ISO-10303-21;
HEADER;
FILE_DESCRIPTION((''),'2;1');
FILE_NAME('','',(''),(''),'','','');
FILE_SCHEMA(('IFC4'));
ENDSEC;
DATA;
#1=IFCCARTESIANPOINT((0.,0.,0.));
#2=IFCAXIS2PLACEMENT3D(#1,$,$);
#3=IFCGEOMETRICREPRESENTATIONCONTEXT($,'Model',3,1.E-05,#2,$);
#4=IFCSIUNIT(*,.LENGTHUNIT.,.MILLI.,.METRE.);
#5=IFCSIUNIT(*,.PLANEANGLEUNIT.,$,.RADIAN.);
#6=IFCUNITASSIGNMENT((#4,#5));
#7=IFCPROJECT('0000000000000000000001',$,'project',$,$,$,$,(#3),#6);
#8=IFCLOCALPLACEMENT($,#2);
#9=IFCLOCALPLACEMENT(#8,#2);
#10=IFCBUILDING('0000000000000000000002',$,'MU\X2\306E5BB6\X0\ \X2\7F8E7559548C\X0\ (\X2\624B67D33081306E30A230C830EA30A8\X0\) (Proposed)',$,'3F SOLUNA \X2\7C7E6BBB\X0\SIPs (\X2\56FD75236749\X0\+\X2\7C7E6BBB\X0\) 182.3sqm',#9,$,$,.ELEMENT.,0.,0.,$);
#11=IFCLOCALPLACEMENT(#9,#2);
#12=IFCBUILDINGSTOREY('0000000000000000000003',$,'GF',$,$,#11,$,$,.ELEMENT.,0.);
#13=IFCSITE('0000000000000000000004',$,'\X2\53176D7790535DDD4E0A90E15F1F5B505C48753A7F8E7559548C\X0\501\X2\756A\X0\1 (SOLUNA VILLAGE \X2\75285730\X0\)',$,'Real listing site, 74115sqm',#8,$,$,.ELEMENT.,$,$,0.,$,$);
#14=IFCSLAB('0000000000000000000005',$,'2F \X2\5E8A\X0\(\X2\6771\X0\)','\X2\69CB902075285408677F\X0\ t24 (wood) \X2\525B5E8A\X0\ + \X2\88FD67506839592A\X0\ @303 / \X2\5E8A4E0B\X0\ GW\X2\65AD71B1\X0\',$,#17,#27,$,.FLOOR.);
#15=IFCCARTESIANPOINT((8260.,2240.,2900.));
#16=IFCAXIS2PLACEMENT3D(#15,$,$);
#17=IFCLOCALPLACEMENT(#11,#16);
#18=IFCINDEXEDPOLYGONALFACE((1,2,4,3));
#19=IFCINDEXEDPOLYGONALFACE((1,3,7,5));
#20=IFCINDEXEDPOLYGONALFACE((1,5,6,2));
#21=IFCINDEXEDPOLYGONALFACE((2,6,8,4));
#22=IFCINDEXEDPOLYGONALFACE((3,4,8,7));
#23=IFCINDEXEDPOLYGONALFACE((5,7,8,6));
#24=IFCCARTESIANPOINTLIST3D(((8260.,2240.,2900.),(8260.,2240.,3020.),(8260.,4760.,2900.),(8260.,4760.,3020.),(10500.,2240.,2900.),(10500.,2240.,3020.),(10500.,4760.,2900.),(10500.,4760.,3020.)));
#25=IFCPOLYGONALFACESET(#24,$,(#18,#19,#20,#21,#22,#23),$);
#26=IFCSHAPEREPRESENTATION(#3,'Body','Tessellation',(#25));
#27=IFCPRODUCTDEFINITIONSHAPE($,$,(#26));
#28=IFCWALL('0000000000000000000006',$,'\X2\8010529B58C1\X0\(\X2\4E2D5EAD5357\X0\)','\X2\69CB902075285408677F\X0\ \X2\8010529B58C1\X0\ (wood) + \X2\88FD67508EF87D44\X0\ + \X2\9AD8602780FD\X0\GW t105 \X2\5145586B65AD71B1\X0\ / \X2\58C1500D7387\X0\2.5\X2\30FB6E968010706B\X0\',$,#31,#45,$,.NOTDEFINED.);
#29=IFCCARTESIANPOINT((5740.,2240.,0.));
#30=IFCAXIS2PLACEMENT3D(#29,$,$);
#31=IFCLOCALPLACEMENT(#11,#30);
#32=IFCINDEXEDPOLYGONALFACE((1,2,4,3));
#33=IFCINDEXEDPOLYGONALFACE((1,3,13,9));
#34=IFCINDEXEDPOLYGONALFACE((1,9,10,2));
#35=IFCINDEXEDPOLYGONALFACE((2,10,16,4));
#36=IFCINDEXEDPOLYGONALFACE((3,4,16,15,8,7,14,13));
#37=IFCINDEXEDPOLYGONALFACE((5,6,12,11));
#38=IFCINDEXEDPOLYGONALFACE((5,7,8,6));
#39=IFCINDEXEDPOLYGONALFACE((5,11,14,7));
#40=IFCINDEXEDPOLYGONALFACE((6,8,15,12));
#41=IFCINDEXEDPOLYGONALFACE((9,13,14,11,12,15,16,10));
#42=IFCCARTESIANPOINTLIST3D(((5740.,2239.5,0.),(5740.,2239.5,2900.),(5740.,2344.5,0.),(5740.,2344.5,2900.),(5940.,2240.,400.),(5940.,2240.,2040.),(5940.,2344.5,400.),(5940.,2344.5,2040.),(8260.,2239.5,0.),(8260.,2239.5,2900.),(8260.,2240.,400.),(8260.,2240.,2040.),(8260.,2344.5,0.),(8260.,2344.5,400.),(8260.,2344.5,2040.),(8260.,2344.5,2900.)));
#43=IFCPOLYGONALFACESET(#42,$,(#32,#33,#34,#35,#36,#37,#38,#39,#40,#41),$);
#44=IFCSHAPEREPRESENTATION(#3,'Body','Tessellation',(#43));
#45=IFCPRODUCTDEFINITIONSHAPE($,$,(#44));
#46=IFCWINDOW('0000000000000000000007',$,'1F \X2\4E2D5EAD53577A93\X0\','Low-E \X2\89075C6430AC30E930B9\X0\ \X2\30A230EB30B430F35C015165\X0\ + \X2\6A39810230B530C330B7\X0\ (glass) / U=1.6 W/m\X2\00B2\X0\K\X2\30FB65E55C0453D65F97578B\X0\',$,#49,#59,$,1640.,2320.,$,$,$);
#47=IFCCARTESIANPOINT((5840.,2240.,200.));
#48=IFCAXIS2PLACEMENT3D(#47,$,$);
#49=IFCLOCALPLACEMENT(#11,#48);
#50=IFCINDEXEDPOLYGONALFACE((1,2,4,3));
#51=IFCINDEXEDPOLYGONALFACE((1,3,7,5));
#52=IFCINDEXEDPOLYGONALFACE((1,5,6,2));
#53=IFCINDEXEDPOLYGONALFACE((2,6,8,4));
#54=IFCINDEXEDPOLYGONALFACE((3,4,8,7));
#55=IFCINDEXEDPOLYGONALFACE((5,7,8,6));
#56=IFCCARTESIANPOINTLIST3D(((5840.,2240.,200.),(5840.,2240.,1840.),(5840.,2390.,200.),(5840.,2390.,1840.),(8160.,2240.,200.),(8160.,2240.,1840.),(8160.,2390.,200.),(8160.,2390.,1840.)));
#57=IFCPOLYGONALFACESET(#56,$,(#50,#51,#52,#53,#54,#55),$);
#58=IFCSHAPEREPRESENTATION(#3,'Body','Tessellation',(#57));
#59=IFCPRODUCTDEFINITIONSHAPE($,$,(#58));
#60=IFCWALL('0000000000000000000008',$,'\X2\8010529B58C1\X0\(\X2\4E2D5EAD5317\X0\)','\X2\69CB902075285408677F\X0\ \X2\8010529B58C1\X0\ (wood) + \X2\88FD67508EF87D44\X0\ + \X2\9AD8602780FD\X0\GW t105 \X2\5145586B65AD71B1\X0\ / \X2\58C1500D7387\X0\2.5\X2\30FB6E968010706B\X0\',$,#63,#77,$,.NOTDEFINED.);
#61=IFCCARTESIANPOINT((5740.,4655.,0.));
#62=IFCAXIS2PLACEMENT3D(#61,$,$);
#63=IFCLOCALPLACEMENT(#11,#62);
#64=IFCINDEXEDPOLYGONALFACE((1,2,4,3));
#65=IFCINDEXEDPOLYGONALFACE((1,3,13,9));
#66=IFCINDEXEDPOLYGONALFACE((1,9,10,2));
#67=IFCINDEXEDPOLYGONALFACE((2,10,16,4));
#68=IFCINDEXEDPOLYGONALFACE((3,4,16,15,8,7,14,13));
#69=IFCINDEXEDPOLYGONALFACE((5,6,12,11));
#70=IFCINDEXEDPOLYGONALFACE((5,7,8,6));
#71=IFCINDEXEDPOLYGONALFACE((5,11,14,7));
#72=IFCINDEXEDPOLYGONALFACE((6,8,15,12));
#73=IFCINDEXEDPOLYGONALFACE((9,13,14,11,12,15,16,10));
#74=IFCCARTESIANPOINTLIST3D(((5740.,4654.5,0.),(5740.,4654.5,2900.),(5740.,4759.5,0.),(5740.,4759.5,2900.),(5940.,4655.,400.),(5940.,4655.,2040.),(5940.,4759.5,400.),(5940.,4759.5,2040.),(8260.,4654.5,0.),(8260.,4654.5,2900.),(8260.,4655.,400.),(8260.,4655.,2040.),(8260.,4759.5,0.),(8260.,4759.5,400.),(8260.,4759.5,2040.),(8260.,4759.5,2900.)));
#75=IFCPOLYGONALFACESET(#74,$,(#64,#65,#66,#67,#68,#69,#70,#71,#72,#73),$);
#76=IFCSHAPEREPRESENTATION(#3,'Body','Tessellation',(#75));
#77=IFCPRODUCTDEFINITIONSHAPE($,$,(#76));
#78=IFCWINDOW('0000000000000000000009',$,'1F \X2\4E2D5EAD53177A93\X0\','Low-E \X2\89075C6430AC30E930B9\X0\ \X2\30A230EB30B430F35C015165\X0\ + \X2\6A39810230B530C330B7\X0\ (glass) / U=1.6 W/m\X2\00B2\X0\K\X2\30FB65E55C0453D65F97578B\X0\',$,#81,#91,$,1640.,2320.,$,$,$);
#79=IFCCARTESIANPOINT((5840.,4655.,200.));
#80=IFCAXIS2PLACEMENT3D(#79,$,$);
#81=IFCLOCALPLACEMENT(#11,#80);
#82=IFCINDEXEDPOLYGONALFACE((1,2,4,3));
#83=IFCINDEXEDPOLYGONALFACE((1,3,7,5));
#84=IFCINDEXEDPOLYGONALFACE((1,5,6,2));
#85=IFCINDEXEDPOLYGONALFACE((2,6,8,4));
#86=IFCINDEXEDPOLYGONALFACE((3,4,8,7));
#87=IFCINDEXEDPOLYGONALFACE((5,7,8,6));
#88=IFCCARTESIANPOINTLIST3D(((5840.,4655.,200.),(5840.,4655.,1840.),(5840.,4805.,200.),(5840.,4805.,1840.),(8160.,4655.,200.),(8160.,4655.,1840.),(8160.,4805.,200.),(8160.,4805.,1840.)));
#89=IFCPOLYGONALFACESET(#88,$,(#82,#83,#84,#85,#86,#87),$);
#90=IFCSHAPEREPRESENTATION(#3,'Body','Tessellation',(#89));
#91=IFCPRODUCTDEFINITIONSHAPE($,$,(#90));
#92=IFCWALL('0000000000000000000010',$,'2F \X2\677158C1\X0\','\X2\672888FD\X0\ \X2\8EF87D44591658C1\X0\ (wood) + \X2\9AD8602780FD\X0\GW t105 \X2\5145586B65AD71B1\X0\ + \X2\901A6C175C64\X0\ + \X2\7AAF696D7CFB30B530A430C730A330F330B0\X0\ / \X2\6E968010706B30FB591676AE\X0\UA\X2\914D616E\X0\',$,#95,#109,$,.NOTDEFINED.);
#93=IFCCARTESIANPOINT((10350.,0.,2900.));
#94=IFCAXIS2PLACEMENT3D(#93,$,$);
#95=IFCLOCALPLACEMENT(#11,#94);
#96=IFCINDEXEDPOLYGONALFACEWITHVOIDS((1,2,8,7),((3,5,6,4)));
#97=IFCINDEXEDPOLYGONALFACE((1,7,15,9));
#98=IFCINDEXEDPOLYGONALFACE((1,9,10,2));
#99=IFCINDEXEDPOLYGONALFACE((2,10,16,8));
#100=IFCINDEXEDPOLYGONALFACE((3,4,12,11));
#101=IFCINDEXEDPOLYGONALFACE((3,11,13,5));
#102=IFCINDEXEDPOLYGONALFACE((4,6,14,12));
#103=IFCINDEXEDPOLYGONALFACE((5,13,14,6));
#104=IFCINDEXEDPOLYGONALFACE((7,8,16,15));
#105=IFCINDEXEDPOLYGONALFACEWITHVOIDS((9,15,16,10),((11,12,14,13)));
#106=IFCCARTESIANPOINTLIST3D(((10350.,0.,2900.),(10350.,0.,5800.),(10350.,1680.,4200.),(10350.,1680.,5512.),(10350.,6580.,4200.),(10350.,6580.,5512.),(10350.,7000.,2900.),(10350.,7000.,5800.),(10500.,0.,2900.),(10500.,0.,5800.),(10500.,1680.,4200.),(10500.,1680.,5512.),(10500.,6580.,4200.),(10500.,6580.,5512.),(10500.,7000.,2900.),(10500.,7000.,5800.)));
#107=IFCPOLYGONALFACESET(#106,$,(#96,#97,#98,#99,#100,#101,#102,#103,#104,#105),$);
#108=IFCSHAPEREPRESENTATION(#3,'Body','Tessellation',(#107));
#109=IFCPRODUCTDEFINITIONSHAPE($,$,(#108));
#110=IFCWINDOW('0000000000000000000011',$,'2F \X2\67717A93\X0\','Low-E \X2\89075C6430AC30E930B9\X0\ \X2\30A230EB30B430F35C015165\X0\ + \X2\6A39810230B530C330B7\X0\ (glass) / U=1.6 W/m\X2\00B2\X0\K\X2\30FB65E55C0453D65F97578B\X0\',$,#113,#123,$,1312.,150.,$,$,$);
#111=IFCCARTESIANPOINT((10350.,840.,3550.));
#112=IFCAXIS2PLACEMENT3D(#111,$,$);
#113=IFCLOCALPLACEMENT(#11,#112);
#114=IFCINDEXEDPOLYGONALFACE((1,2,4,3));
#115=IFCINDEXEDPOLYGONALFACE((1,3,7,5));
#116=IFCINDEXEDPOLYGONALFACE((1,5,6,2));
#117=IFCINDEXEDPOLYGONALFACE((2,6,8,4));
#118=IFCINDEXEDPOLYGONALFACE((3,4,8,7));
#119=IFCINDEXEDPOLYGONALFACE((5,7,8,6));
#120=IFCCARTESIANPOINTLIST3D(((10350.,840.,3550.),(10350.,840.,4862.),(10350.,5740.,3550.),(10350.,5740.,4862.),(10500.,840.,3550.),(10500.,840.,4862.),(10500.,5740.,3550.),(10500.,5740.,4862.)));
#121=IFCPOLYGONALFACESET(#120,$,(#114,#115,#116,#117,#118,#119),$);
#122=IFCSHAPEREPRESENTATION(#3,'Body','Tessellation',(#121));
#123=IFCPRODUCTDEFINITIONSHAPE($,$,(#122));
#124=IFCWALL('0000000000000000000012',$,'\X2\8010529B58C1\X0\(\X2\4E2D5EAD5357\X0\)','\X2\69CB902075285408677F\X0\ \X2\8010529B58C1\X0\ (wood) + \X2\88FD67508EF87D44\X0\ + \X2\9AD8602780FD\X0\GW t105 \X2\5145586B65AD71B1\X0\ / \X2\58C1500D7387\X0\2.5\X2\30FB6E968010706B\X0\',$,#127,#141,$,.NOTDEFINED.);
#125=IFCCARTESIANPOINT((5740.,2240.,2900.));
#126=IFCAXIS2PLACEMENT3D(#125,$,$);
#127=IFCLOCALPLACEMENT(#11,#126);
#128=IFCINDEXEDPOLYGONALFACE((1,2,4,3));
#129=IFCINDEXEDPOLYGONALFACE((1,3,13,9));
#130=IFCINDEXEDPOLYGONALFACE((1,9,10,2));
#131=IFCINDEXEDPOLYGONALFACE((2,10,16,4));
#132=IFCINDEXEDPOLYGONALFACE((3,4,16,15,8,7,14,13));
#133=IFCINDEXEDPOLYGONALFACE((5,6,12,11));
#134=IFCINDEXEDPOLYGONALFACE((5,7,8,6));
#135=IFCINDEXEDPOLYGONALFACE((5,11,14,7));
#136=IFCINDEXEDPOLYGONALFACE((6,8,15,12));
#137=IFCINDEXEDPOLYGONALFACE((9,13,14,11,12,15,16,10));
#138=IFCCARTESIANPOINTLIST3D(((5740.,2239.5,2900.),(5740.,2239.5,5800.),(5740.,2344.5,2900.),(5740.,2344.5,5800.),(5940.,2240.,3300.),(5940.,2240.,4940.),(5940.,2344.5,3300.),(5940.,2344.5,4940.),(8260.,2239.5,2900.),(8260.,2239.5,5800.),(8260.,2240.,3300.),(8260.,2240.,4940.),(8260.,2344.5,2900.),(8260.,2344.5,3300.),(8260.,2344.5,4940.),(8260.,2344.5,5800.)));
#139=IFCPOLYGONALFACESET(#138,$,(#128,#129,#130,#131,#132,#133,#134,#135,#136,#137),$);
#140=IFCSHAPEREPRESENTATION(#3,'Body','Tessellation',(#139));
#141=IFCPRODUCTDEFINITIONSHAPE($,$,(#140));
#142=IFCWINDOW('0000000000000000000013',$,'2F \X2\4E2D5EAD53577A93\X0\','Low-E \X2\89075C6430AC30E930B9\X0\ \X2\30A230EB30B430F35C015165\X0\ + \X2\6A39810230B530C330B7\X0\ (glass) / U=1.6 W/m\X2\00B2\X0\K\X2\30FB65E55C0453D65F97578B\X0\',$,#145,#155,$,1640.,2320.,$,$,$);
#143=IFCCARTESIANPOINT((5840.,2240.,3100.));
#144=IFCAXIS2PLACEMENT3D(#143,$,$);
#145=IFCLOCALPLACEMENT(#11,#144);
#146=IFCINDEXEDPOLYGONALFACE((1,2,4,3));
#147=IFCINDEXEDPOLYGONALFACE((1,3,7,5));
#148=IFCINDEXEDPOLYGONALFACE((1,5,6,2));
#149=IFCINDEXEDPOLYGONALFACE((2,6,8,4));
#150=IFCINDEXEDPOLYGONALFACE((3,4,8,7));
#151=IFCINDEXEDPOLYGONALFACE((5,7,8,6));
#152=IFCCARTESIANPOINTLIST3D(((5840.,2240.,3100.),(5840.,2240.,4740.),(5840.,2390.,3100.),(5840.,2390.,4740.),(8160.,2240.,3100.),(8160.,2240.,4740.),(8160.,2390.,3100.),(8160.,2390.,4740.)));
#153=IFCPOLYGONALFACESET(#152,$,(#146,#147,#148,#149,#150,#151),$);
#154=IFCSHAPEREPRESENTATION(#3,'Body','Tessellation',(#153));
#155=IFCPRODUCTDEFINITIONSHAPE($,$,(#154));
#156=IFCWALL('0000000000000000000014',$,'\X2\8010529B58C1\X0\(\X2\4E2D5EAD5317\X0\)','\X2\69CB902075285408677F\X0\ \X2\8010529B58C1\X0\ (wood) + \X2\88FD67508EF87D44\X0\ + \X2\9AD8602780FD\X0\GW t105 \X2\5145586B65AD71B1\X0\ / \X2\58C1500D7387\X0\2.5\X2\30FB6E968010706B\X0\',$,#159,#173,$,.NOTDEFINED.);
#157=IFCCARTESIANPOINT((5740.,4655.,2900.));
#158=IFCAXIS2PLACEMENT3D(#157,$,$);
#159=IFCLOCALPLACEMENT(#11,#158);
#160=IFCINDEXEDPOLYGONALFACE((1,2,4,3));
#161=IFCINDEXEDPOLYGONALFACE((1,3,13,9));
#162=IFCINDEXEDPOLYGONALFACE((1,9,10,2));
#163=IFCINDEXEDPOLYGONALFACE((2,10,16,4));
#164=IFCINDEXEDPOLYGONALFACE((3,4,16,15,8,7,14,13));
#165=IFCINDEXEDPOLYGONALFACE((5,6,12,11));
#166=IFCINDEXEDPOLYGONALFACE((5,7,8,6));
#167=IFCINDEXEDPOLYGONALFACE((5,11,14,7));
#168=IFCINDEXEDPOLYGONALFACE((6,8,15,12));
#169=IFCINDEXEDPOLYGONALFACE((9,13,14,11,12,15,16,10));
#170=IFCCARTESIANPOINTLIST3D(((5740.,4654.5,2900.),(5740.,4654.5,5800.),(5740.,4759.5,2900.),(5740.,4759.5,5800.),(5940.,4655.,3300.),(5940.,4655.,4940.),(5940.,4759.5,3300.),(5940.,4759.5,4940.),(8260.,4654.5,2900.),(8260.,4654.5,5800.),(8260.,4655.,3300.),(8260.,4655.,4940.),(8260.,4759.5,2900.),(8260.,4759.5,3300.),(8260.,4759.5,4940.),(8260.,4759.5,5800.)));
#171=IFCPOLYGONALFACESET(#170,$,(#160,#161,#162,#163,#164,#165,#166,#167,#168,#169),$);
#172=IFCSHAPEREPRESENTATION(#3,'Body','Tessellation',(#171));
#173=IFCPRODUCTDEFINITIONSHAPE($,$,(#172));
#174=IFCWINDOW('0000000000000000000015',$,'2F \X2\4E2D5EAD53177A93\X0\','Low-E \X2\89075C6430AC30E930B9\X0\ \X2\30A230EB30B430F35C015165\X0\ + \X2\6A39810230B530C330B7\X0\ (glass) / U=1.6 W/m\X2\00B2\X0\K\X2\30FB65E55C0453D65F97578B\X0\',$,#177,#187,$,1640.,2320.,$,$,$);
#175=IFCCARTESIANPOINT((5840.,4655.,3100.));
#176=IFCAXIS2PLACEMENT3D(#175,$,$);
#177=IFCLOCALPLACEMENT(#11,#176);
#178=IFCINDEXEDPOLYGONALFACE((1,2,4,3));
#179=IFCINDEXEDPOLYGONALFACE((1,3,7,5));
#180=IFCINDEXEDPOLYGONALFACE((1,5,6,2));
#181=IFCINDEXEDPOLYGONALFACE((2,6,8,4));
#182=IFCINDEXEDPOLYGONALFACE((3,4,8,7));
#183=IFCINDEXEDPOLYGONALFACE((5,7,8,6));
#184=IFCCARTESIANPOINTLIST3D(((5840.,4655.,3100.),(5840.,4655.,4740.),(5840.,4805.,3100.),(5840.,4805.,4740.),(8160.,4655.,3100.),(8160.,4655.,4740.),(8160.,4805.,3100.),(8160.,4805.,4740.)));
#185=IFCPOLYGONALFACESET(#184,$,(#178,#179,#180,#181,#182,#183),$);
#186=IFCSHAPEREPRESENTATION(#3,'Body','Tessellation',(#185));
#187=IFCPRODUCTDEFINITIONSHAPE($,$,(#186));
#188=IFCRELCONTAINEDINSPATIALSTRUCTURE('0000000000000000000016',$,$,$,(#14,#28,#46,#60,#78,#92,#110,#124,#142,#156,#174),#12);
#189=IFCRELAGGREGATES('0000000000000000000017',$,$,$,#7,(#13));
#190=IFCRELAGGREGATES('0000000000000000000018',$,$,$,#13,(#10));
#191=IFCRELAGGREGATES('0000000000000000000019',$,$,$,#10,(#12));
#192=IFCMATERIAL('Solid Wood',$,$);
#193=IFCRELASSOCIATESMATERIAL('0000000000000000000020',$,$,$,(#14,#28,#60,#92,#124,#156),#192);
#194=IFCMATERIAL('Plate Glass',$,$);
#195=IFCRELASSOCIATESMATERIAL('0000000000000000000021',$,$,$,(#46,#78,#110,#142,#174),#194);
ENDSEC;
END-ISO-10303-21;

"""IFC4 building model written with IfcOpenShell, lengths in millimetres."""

from ifc_helpers import new_model, si_unit, frame, frame_2d, origin, place, context, project, spatial, rectangle, extrude, material, element, fill, save


model = new_model("IFC4")

# Units and contexts
model_context = context("Model", 3, precision=1e-05, world=origin())
ifc_project = project(units=[si_unit("LENGTHUNIT", "METRE", prefix="MILLI"), si_unit("PLANEANGLEUNIT", "RADIAN")], contexts=[model_context])

# Site, building, storey
site_placement = place(None, origin())
site = spatial("IfcSite", under=ifc_project, at=site_placement, Name="北海道川上郡弟子屈町美留和501番1 (SOLUNA VILLAGE 用地)", ObjectType="Real listing site, 74115sqm", CompositionType="ELEMENT", RefElevation=0.0)
building_placement = place(site_placement, origin())
building = spatial("IfcBuilding", under=site, at=building_placement, Name="MUの家 美留和 (手染めのアトリエ) (Proposed)", ObjectType="3F SOLUNA 籾殻SIPs (国産杉+籾殻) 182.3sqm", CompositionType="ELEMENT", ElevationOfRefHeight=0.0, ElevationOfTerrain=0.0)
storey_placement = place(building_placement, origin())
storey = spatial("IfcBuildingStorey", under=building, at=storey_placement, Name="GF", CompositionType="ELEMENT", Elevation=0.0)

# Slab
ifc_material_1 = material(Name="Solid Wood")
slab_1_placement = place(storey_placement, frame((8260.0, 2240.0, 2900.0)))
element("IfcSlab", 1, at=slab_1_placement, inside=storey, material=ifc_material_1, Name="2F 床(東)", Description="構造用合板 t24 (wood) 剛床 + 製材根太 @303 / 床下 GW断熱", PredefinedType="FLOOR", context=model_context, shape_type="SweptSolid", body=[
    extrude(rectangle(XDim=2240.0, YDim=2520.0, at=frame_2d((1120.0, 1260.0))), frame((8260.0, 2240.0, 2900.0)), (0.0, 0.0, 1.0), 120.0),
])

# Walls, openings, windows
ifc_material_2 = material(Name="Plate Glass")
wall_1_placement = place(storey_placement, frame((5740.0, 2240.0, 0.0)))
wall_1 = element("IfcWall", 2, at=wall_1_placement, inside=storey, material=ifc_material_1, Name="耐力壁(中庭南)", Description="構造用合板 耐力壁 (wood) + 製材軸組 + 高性能GW t105 充填断熱 / 壁倍率2.5・準耐火", PredefinedType="NOTDEFINED", context=model_context, shape_type="SweptSolid", body=[
    extrude(rectangle(XDim=2520.0, YDim=105.0, at=frame_2d((1260.0, 52.0))), frame((5740.0, 2240.0, 0.0)), (0.0, 0.0, 1.0), 2900.0),
])
opening_1_placement = place(storey_placement, frame((5840.0, 2240.0, 200.0)))
opening_1 = element("IfcOpeningElement", 3, at=opening_1_placement, cuts=wall_1, PredefinedType="NOTDEFINED", context=model_context, shape_type="SweptSolid", body=[
    extrude(rectangle(XDim=2320.0, YDim=150.0, at=frame_2d((1160.0, 75.0))), frame((5840.0, 2240.0, 200.0)), (0.0, 0.0, 1.0), 1640.0),
])
window_1_placement = place(storey_placement, frame((5840.0, 2240.0, 200.0)))
window_1 = element("IfcWindow", 4, at=window_1_placement, inside=storey, material=ifc_material_2, Name="1F 中庭南窓", Description="Low-E 複層ガラス アルゴン封入 + 樹脂サッシ (glass) / U=1.6 W/m²K・日射取得型", OverallHeight=1640.0, OverallWidth=2320.0, context=model_context, shape_type="SweptSolid", body=[
    extrude(rectangle(XDim=2320.0, YDim=150.0, at=frame_2d((1160.0, 75.0))), frame((5840.0, 2240.0, 200.0)), (0.0, 0.0, 1.0), 1640.0),
])
fill(opening_1, window_1)
wall_2_placement = place(storey_placement, frame((5740.0, 4655.0, 0.0)))
wall_2 = element("IfcWall", 5, at=wall_2_placement, inside=storey, material=ifc_material_1, Name="耐力壁(中庭北)", Description="構造用合板 耐力壁 (wood) + 製材軸組 + 高性能GW t105 充填断熱 / 壁倍率2.5・準耐火", PredefinedType="NOTDEFINED", context=model_context, shape_type="SweptSolid", body=[
    extrude(rectangle(XDim=2520.0, YDim=105.0, at=frame_2d((1260.0, 52.0))), frame((5740.0, 4655.0, 0.0)), (0.0, 0.0, 1.0), 2900.0),
])
opening_2_placement = place(storey_placement, frame((5840.0, 4655.0, 200.0)))
opening_2 = element("IfcOpeningElement", 6, at=opening_2_placement, cuts=wall_2, PredefinedType="NOTDEFINED", context=model_context, shape_type="SweptSolid", body=[
    extrude(rectangle(XDim=2320.0, YDim=150.0, at=frame_2d((1160.0, 75.0))), frame((5840.0, 4655.0, 200.0)), (0.0, 0.0, 1.0), 1640.0),
])
window_2_placement = place(storey_placement, frame((5840.0, 4655.0, 200.0)))
window_2 = element("IfcWindow", 7, at=window_2_placement, inside=storey, material=ifc_material_2, Name="1F 中庭北窓", Description="Low-E 複層ガラス アルゴン封入 + 樹脂サッシ (glass) / U=1.6 W/m²K・日射取得型", OverallHeight=1640.0, OverallWidth=2320.0, context=model_context, shape_type="SweptSolid", body=[
    extrude(rectangle(XDim=2320.0, YDim=150.0, at=frame_2d((1160.0, 75.0))), frame((5840.0, 4655.0, 200.0)), (0.0, 0.0, 1.0), 1640.0),
])
fill(opening_2, window_2)

# Walls, openings, windows
wall_3_placement = place(storey_placement, frame((10350.0, 0.0, 2900.0)))
wall_3 = element("IfcWall", 8, at=wall_3_placement, inside=storey, material=ifc_material_1, Name="2F 東壁", Description="木製 軸組外壁 (wood) + 高性能GW t105 充填断熱 + 通気層 + 窯業系サイディング / 準耐火・外皮UA配慮", PredefinedType="NOTDEFINED", context=model_context, shape_type="SweptSolid", body=[
    extrude(rectangle(XDim=150.0, YDim=7000.0, at=frame_2d((75.0, 3500.0))), frame((10350.0, 0.0, 2900.0)), (0.0, 0.0, 1.0), 2900.0),
])
opening_3_placement = place(storey_placement, frame((10350.0, 840.0, 3550.0)))
opening_3 = element("IfcOpeningElement", 9, at=opening_3_placement, cuts=wall_3, PredefinedType="NOTDEFINED", context=model_context, shape_type="SweptSolid", body=[
    extrude(rectangle(XDim=150.0, YDim=4900.0, at=frame_2d((75.0, 2450.0))), frame((10350.0, 840.0, 3550.0)), (0.0, 0.0, 1.0), 1312.0),
])
window_3_placement = place(storey_placement, frame((10350.0, 840.0, 3550.0)))
window_3 = element("IfcWindow", 10, at=window_3_placement, inside=storey, material=ifc_material_2, Name="2F 東窓", Description="Low-E 複層ガラス アルゴン封入 + 樹脂サッシ (glass) / U=1.6 W/m²K・日射取得型", OverallHeight=1312.0, OverallWidth=150.0, context=model_context, shape_type="SweptSolid", body=[
    extrude(rectangle(XDim=150.0, YDim=4900.0, at=frame_2d((75.0, 2450.0))), frame((10350.0, 840.0, 3550.0)), (0.0, 0.0, 1.0), 1312.0),
])
fill(opening_3, window_3)
wall_4_placement = place(storey_placement, frame((5740.0, 2240.0, 2900.0)))
wall_4 = element("IfcWall", 11, at=wall_4_placement, inside=storey, material=ifc_material_1, Name="耐力壁(中庭南)", Description="構造用合板 耐力壁 (wood) + 製材軸組 + 高性能GW t105 充填断熱 / 壁倍率2.5・準耐火", PredefinedType="NOTDEFINED", context=model_context, shape_type="SweptSolid", body=[
    extrude(rectangle(XDim=2520.0, YDim=105.0, at=frame_2d((1260.0, 52.0))), frame((5740.0, 2240.0, 2900.0)), (0.0, 0.0, 1.0), 2900.0),
])
opening_4_placement = place(storey_placement, frame((5840.0, 2240.0, 3100.0)))
opening_4 = element("IfcOpeningElement", 12, at=opening_4_placement, cuts=wall_4, PredefinedType="NOTDEFINED", context=model_context, shape_type="SweptSolid", body=[
    extrude(rectangle(XDim=2320.0, YDim=150.0, at=frame_2d((1160.0, 75.0))), frame((5840.0, 2240.0, 3100.0)), (0.0, 0.0, 1.0), 1640.0),
])
window_4_placement = place(storey_placement, frame((5840.0, 2240.0, 3100.0)))
window_4 = element("IfcWindow", 13, at=window_4_placement, inside=storey, material=ifc_material_2, Name="2F 中庭南窓", Description="Low-E 複層ガラス アルゴン封入 + 樹脂サッシ (glass) / U=1.6 W/m²K・日射取得型", OverallHeight=1640.0, OverallWidth=2320.0, context=model_context, shape_type="SweptSolid", body=[
    extrude(rectangle(XDim=2320.0, YDim=150.0, at=frame_2d((1160.0, 75.0))), frame((5840.0, 2240.0, 3100.0)), (0.0, 0.0, 1.0), 1640.0),
])
fill(opening_4, window_4)
wall_5_placement = place(storey_placement, frame((5740.0, 4655.0, 2900.0)))
wall_5 = element("IfcWall", 14, at=wall_5_placement, inside=storey, material=ifc_material_1, Name="耐力壁(中庭北)", Description="構造用合板 耐力壁 (wood) + 製材軸組 + 高性能GW t105 充填断熱 / 壁倍率2.5・準耐火", PredefinedType="NOTDEFINED", context=model_context, shape_type="SweptSolid", body=[
    extrude(rectangle(XDim=2520.0, YDim=105.0, at=frame_2d((1260.0, 52.0))), frame((5740.0, 4655.0, 2900.0)), (0.0, 0.0, 1.0), 2900.0),
])
opening_5_placement = place(storey_placement, frame((5840.0, 4655.0, 3100.0)))
opening_5 = element("IfcOpeningElement", 15, at=opening_5_placement, cuts=wall_5, PredefinedType="NOTDEFINED", context=model_context, shape_type="SweptSolid", body=[
    extrude(rectangle(XDim=2320.0, YDim=150.0, at=frame_2d((1160.0, 75.0))), frame((5840.0, 4655.0, 3100.0)), (0.0, 0.0, 1.0), 1640.0),
])
window_5_placement = place(storey_placement, frame((5840.0, 4655.0, 3100.0)))
window_5 = element("IfcWindow", 16, at=window_5_placement, inside=storey, material=ifc_material_2, Name="2F 中庭北窓", Description="Low-E 複層ガラス アルゴン封入 + 樹脂サッシ (glass) / U=1.6 W/m²K・日射取得型", OverallHeight=1640.0, OverallWidth=2320.0, context=model_context, shape_type="SweptSolid", body=[
    extrude(rectangle(XDim=2320.0, YDim=150.0, at=frame_2d((1160.0, 75.0))), frame((5840.0, 4655.0, 3100.0)), (0.0, 0.0, 1.0), 1640.0),
])
fill(opening_5, window_5)

save(model, "model.ifc")
